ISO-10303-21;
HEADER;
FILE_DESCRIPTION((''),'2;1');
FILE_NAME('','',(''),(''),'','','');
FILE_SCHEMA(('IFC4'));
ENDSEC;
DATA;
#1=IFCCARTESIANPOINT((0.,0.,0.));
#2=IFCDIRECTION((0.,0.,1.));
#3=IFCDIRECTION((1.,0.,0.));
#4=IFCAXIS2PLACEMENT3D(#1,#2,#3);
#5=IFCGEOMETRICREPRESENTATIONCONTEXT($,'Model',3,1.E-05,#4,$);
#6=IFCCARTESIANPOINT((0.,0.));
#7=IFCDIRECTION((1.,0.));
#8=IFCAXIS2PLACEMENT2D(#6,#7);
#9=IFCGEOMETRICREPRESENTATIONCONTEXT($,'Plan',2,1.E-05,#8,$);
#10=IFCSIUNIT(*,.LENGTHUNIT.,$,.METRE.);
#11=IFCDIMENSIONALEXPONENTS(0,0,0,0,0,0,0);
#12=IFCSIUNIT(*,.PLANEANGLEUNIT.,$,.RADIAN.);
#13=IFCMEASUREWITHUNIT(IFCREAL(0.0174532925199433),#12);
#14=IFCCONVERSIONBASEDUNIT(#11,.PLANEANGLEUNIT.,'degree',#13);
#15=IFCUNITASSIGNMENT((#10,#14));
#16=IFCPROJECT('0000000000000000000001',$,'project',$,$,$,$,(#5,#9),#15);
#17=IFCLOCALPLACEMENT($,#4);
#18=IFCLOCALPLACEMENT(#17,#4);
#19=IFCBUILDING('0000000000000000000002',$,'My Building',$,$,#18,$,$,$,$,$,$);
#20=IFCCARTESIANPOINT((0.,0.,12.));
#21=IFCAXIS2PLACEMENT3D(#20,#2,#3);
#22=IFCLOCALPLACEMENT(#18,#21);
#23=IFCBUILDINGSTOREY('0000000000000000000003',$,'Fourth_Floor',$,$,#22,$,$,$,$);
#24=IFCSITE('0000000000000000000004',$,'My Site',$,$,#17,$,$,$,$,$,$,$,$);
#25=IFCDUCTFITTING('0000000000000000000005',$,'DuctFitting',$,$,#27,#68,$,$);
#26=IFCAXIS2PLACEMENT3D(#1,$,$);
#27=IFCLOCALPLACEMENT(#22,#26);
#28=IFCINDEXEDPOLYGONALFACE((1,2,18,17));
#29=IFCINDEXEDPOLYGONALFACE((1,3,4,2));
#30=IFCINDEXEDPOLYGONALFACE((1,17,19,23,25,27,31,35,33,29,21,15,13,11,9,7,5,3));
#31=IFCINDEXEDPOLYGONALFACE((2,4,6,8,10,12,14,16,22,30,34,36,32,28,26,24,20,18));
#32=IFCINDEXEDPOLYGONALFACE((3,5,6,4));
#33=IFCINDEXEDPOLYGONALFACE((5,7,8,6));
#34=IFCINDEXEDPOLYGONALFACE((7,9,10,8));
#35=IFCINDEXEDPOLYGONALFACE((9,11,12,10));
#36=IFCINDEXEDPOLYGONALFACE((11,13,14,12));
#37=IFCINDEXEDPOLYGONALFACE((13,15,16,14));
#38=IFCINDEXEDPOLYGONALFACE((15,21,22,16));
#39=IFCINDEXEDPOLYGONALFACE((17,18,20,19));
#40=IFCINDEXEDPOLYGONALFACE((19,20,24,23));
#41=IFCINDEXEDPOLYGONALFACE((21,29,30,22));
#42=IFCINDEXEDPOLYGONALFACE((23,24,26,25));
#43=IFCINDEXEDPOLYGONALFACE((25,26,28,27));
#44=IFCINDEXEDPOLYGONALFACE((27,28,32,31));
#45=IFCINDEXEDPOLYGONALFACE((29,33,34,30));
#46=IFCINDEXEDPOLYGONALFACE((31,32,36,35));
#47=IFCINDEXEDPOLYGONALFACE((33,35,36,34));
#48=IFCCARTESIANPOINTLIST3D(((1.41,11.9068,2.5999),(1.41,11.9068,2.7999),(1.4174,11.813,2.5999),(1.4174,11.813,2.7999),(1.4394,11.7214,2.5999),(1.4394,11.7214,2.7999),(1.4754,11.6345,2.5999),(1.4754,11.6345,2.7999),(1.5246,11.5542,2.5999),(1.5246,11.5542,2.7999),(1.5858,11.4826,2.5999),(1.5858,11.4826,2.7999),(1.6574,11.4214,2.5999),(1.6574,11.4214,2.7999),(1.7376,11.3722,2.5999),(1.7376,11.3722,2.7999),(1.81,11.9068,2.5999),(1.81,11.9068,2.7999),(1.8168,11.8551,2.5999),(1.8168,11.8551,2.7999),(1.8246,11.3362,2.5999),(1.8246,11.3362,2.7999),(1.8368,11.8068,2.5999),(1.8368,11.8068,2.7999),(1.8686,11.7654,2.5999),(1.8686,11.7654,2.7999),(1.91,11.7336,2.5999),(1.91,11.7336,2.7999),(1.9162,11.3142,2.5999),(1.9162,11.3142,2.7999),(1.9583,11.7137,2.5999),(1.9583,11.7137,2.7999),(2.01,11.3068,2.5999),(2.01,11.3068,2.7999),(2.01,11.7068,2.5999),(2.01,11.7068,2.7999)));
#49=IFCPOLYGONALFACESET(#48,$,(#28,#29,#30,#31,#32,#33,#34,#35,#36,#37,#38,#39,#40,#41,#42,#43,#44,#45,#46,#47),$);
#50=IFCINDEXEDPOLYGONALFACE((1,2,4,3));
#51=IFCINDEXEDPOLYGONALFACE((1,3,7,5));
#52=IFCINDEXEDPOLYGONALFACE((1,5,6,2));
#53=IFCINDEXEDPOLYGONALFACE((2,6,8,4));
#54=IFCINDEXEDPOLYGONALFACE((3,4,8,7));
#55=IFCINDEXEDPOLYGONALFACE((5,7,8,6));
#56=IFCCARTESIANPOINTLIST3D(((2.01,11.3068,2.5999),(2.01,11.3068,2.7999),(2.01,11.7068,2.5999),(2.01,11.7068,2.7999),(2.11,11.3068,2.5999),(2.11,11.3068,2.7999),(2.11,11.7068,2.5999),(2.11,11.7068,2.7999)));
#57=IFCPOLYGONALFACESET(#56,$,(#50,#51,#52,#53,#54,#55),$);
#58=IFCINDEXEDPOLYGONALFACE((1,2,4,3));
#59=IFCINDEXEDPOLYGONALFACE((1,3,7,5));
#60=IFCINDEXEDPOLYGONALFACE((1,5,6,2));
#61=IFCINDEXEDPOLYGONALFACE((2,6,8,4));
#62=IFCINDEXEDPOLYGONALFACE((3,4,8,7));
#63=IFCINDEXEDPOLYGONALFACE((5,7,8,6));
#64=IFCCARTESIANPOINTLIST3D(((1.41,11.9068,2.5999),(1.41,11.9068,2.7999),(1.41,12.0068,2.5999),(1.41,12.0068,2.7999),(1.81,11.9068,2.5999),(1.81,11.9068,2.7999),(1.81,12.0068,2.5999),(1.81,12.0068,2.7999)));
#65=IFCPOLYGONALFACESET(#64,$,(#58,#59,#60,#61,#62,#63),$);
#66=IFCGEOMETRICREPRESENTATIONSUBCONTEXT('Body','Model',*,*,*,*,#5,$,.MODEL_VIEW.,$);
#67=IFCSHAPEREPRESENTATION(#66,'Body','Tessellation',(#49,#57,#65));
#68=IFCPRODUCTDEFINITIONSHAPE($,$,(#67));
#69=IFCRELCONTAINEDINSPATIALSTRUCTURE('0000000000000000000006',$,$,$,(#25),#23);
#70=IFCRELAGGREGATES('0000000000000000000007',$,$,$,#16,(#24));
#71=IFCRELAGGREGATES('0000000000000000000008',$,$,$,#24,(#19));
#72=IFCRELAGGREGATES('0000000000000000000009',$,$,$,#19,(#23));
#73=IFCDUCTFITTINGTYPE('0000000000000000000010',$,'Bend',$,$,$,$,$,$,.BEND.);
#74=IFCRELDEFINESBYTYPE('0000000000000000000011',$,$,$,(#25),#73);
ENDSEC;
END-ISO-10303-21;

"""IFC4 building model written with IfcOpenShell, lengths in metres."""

from ifc_helpers import new_model, entity, si_unit, converted_unit, frame, origin_with_axes, origin_2d_with_axis, place, context, subcontext, project, spatial, line, arc, indexed_curve, rectangle, outline, extrude, source, transform, mapped, type_object, type_shapes, element, save


model = new_model("IFC4")

# Units and contexts
model_context = context("Model", 3, precision=1e-05, world=origin_with_axes())
plan_context = context("Plan", 2, precision=1e-05, world=origin_2d_with_axis())
body_context_1 = subcontext(model_context, "Body", "Model", "MODEL_VIEW")
ifc_project = project(units=[si_unit("LENGTHUNIT", "METRE"), converted_unit("PLANEANGLEUNIT", "degree", entity("IfcReal", 0.0174532925199433), si_unit("PLANEANGLEUNIT", "RADIAN"), dimensions=[0, 0, 0, 0, 0, 0, 0])], contexts=[model_context, plan_context])

# Site, building, storey
site_placement = place(None, origin_with_axes())
site = spatial("IfcSite", under=ifc_project, at=site_placement, Name="My Site")
building_placement = place(site_placement, origin_with_axes())
building = spatial("IfcBuilding", under=site, at=building_placement, Name="My Building")
storey_placement = place(building_placement, frame((0.0, 0.0, 12.0), z_axis=(0.0, 0.0, 1.0), x_axis=(1.0, 0.0, 0.0)))
storey = spatial("IfcBuildingStorey", under=building, at=storey_placement, Name="Fourth_Floor")

# Duct fitting
duct_fitting_type = type_object("IfcDuctFittingType", Name="Bend", PredefinedType="BEND")
shared_shape_1 = source(origin_with_axes(), body_context_1, "Body", "SweptSolid", [
    extrude(outline(indexed_curve([(-0.2, 0.0), (-0.2586, 0.1414), (-0.4, 0.2), (-0.4, 0.6), (0.0243, 0.4243), (0.2, 0.0)], segments=[arc(1, 2, 3), line(3, 4), arc(4, 5, 6), line(6, 1)])), frame((0.0, -0.1, 0.1), z_axis=(0.0, -1.0, 0.0), x_axis=(1.0, 0.0, 0.0)), (0.0, 0.0, -1.0), 0.2),
    extrude(rectangle(XDim=0.4, YDim=0.2), origin_with_axes(), (0.0, 0.0, 1.0), 0.1),
    extrude(rectangle(XDim=0.4, YDim=0.2), frame((-0.4, 0.0, 0.5), z_axis=(-1.0, 0.0, 0.0), x_axis=(0.0, 0.0, -1.0)), (0.0, 0.0, 1.0), 0.1),
])
type_shapes(duct_fitting_type, [shared_shape_1])
duct_fitting_placement = place(storey_placement, frame((2.11, 11.5068, 2.6999), z_axis=(-1.0, 0.0, 0.0), x_axis=(0.0, -1.0, 0.0)))
element("IfcDuctFitting", 1, at=duct_fitting_placement, inside=storey, type_object=duct_fitting_type, Name="DuctFitting", context=body_context_1, shape_type="MappedRepresentation", body=[
    mapped(shared_shape_1, transform((0.0, 0.0, 0.0), x_axis=(1.0, 0.0, 0.0), y_axis=(0.0, 1.0, 0.0), z_axis=(0.0, 0.0, 1.0), scale=1.0)),
])

save(model, "model.ifc")
